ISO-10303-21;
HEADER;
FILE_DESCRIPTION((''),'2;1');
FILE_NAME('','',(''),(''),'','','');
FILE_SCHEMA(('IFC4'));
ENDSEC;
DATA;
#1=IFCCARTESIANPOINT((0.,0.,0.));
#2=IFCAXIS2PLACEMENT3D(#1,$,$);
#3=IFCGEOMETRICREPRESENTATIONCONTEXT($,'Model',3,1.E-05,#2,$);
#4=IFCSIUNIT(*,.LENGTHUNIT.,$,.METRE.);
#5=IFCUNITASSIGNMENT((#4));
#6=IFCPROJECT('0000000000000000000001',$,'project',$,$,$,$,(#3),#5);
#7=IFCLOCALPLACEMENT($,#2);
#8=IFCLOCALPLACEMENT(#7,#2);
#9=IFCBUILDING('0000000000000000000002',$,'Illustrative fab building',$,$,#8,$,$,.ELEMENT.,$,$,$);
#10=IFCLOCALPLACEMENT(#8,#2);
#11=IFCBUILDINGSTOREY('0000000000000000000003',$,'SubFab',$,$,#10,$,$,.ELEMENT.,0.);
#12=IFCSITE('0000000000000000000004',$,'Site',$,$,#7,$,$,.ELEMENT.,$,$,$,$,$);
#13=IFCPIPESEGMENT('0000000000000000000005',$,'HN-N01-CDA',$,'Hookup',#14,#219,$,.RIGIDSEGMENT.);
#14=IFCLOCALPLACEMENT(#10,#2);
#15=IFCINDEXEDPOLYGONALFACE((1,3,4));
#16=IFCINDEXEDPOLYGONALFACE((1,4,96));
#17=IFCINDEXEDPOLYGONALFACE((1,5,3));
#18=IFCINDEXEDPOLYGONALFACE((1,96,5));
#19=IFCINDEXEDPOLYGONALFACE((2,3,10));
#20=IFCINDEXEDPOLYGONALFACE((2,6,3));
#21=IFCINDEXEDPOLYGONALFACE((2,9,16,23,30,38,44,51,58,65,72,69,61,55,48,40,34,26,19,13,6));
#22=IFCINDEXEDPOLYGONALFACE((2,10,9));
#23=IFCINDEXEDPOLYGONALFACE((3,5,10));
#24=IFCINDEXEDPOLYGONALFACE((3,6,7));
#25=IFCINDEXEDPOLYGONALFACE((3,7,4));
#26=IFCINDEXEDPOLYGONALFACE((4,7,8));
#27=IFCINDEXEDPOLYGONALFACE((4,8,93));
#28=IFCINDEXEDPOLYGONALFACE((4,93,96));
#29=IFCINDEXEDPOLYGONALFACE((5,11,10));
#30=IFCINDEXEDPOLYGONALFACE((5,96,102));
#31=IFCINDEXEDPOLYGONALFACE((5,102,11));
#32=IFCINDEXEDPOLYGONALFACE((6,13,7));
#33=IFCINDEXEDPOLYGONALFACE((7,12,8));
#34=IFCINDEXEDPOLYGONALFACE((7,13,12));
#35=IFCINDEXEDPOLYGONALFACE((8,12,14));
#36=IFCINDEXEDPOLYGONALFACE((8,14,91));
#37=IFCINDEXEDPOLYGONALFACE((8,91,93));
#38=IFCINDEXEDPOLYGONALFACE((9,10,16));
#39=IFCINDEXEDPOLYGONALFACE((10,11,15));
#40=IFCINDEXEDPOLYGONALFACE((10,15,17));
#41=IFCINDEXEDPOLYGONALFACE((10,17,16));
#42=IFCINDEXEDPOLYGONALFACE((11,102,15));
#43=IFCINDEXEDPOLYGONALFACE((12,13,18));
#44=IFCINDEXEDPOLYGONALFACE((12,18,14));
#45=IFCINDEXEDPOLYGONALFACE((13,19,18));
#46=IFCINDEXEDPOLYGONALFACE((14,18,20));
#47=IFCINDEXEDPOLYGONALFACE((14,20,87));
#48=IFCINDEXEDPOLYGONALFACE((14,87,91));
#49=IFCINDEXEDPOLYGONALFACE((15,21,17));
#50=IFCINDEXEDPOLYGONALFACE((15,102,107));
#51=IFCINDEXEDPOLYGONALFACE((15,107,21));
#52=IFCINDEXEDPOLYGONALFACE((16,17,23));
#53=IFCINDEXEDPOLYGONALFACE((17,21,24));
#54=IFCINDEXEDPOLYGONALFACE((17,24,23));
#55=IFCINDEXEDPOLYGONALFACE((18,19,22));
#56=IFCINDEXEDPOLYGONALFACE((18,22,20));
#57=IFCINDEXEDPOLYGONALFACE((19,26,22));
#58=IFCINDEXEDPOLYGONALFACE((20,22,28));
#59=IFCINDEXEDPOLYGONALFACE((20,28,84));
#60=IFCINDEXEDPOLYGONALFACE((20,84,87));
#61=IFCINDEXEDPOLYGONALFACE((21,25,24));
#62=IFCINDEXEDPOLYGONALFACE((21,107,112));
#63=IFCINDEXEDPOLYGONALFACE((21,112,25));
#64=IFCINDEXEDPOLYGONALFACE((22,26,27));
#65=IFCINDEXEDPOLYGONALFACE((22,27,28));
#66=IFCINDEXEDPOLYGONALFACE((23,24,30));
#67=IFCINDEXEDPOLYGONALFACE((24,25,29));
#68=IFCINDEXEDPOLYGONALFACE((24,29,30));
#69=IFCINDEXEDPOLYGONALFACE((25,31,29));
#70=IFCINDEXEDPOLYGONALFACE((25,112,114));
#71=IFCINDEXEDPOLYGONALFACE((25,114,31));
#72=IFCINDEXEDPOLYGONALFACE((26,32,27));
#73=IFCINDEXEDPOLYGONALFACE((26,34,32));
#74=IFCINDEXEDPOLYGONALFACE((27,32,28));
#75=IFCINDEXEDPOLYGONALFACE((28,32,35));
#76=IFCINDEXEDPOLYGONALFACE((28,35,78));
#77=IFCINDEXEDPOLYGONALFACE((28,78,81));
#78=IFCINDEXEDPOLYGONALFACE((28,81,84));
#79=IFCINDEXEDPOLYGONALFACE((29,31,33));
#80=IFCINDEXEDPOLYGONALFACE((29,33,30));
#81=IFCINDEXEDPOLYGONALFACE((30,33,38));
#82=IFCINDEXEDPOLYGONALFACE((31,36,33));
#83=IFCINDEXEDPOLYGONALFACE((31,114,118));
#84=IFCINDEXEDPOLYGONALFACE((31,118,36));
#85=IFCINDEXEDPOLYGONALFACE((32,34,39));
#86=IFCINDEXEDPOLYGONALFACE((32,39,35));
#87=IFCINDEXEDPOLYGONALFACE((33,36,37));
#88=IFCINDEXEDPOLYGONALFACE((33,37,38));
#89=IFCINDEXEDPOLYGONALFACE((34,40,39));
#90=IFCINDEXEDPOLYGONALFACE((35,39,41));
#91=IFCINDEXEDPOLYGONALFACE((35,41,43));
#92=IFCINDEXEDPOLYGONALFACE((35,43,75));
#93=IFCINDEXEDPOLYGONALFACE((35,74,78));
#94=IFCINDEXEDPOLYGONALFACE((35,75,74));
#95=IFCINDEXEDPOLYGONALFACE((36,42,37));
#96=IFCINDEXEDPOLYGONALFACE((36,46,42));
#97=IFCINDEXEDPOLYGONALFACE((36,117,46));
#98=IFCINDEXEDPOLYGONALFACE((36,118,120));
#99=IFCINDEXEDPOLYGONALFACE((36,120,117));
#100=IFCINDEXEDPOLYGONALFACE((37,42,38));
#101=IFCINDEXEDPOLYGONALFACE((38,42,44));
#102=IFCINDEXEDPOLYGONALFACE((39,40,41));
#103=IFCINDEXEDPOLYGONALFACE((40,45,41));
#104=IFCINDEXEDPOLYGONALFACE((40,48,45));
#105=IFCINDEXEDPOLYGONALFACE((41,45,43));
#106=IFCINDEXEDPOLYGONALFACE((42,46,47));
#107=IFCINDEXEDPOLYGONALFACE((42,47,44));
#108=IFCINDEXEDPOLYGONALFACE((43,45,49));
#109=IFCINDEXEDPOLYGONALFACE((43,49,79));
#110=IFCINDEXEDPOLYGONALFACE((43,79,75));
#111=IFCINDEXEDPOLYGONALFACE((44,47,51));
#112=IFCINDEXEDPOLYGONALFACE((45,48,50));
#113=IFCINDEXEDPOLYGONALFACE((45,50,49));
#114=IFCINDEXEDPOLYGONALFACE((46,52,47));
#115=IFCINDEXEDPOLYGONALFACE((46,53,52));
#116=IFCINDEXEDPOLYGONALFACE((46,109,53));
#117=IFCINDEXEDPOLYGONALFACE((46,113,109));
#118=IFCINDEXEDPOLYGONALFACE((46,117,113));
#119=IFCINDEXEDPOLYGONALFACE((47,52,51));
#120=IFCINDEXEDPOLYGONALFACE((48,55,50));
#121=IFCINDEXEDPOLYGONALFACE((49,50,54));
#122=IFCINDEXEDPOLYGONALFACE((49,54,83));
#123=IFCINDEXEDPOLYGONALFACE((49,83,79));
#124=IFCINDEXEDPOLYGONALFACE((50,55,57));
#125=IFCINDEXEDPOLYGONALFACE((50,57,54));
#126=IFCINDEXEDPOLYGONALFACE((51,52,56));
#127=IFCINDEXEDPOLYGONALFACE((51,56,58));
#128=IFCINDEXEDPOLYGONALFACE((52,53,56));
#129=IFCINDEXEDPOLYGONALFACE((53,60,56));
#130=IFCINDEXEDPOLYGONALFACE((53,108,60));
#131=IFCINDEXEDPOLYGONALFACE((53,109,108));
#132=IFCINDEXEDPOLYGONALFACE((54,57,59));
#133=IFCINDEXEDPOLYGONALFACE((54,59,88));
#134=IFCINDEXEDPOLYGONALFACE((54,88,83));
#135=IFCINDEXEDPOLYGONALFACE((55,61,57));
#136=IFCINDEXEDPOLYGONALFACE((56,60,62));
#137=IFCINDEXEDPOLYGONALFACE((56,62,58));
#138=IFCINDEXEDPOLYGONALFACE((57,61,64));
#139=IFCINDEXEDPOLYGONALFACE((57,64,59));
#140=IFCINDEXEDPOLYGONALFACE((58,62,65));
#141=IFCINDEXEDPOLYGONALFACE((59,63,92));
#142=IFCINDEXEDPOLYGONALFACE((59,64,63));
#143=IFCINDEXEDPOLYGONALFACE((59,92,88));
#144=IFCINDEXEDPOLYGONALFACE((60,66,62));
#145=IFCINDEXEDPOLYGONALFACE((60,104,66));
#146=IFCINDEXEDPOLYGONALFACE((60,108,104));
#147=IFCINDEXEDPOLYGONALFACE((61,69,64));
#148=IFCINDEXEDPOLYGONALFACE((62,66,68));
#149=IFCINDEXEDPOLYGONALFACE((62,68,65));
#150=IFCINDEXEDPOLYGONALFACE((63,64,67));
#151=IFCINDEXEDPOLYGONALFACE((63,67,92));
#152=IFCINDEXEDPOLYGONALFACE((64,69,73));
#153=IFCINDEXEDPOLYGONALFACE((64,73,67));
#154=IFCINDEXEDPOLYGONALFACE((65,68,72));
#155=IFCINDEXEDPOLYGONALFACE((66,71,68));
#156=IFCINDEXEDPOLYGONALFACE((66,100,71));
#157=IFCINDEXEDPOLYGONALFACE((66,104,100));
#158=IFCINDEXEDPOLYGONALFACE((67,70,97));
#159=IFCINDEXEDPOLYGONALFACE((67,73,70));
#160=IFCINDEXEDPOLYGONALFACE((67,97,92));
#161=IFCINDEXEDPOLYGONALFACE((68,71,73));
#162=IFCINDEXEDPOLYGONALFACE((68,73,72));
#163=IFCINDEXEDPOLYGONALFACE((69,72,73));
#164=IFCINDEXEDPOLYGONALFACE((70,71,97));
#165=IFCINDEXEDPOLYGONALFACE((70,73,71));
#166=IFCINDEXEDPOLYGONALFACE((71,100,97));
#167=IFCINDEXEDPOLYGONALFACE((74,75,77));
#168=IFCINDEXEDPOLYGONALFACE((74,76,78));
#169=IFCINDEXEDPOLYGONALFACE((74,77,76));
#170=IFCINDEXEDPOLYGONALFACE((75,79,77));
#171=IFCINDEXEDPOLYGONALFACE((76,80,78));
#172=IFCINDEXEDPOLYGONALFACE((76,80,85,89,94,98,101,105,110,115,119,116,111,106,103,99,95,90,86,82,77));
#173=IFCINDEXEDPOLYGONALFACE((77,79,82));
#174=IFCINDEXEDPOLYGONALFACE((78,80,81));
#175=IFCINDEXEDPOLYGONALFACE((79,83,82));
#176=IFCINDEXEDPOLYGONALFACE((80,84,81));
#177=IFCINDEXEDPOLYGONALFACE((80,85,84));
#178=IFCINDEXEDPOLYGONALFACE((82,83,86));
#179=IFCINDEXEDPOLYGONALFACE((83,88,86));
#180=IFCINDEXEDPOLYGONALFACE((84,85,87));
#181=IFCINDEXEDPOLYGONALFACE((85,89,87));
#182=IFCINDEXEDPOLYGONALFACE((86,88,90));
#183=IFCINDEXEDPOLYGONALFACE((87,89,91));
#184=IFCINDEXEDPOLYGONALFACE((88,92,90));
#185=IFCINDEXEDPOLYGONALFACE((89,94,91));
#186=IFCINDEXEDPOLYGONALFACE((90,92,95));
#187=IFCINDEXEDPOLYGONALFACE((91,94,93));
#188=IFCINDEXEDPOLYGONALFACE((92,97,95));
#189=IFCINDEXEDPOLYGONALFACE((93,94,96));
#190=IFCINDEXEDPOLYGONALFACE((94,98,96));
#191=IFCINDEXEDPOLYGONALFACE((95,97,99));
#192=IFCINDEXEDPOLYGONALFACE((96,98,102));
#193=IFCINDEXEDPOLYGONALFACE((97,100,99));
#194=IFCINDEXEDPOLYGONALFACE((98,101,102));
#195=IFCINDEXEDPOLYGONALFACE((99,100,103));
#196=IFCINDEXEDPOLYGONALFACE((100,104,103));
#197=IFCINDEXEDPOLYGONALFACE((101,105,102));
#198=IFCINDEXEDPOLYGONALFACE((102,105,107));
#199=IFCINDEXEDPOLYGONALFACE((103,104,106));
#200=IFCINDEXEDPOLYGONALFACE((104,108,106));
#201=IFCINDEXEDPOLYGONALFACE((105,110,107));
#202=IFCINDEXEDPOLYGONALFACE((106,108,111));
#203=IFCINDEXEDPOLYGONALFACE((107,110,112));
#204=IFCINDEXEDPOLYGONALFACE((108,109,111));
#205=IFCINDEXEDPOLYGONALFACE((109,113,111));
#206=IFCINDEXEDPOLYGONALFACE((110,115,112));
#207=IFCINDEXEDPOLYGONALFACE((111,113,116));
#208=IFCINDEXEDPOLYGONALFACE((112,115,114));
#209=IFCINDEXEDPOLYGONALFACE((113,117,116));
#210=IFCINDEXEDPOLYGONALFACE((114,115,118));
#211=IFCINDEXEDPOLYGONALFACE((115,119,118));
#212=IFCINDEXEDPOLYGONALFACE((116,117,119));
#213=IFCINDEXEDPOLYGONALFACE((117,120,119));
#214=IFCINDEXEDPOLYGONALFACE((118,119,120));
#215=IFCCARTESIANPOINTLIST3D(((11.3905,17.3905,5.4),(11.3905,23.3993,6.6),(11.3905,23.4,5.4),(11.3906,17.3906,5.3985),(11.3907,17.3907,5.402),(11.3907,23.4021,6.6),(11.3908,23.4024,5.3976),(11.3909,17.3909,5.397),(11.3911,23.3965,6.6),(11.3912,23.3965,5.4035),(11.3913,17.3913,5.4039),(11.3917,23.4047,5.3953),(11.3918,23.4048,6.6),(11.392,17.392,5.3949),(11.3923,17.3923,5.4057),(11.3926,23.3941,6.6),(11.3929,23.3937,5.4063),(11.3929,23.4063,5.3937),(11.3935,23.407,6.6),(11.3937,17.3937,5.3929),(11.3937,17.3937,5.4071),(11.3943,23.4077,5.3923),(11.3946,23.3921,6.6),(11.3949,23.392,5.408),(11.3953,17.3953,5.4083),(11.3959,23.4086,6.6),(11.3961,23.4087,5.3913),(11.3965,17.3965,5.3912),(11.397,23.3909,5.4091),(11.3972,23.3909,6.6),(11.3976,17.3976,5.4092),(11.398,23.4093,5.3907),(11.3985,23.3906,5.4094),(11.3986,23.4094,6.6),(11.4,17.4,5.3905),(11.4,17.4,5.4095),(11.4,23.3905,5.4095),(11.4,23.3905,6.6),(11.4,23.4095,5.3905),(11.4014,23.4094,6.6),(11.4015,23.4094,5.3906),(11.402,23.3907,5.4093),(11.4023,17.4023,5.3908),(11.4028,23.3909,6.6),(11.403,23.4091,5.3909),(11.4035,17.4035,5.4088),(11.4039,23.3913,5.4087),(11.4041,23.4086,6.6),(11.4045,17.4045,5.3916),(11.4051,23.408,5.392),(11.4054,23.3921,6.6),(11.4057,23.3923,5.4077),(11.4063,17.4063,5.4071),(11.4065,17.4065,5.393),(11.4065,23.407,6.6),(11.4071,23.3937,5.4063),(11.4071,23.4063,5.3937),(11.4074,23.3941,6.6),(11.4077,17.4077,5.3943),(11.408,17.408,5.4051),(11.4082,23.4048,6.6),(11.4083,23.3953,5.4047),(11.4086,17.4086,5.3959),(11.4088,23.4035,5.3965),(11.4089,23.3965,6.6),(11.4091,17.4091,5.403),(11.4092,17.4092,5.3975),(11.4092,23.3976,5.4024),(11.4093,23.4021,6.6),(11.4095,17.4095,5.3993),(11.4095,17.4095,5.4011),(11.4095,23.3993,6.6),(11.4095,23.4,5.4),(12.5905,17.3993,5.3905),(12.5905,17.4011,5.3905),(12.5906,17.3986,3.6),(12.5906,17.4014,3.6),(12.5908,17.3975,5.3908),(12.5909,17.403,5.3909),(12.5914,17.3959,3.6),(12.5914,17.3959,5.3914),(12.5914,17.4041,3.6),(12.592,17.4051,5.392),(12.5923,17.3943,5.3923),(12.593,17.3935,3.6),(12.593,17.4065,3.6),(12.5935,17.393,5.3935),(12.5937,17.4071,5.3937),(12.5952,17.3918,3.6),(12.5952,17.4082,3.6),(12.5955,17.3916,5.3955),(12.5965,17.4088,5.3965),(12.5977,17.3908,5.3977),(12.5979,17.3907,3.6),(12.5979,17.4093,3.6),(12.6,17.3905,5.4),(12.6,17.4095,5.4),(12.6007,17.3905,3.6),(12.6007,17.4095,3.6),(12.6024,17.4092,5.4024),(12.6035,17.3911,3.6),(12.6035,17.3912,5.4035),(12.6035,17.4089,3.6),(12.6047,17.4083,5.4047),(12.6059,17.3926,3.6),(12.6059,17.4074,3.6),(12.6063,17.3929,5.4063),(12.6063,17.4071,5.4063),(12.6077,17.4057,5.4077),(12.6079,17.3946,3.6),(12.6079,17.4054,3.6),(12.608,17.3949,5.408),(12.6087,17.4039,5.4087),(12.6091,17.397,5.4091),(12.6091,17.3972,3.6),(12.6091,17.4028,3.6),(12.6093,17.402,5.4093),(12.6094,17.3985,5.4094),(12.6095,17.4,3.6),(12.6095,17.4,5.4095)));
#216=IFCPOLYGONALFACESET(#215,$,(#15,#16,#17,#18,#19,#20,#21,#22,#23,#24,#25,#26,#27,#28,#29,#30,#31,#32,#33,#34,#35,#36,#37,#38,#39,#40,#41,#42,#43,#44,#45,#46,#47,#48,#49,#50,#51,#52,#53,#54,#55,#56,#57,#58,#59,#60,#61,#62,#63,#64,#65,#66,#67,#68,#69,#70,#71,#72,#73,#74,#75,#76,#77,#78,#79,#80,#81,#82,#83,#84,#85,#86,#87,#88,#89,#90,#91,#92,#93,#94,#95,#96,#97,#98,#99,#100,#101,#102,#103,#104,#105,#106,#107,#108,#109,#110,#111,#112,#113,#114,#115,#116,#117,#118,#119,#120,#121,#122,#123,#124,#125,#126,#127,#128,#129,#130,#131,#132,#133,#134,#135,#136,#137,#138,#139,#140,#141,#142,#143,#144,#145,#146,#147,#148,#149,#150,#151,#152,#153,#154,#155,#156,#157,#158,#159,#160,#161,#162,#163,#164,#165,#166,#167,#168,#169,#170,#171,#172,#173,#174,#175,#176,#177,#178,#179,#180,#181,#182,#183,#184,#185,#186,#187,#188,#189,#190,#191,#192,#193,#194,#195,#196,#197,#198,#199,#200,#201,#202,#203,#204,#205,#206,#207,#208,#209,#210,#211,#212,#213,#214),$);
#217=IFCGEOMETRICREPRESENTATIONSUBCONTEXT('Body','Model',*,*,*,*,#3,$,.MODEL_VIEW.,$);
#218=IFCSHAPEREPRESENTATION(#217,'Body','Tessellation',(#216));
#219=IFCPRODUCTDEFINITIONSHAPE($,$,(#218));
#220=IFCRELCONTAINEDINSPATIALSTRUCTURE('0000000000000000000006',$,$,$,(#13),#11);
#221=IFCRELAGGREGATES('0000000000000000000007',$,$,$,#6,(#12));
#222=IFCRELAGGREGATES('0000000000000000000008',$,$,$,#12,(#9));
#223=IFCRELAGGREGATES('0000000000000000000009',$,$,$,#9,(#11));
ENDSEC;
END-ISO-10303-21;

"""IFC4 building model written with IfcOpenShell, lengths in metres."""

from ifc_helpers import new_model, entity, si_unit, origin, place, context, subcontext, project, spatial, element, save


model = new_model("IFC4")

# Units and contexts
model_context = context("Model", 3, precision=1e-05, world=origin())
body_context = subcontext(model_context, "Body", "Model", "MODEL_VIEW")
ifc_project = project(units=[si_unit("LENGTHUNIT", "METRE")], contexts=[model_context])

# Site, building, storey
site_placement = place(None, origin())
site = spatial("IfcSite", under=ifc_project, at=site_placement, Name="Site", CompositionType="ELEMENT")
building_placement = place(site_placement, origin())
building = spatial("IfcBuilding", under=site, at=building_placement, Name="Illustrative fab building", CompositionType="ELEMENT")
storey_placement = place(building_placement, origin())
storey = spatial("IfcBuildingStorey", under=building, at=storey_placement, Name="SubFab", CompositionType="ELEMENT", Elevation=0.0)

# Pipe segment
pipe_segment_1_placement = place(storey_placement, origin())
element("IfcPipeSegment", 1, at=pipe_segment_1_placement, inside=storey, Name="HN-N01-CDA", ObjectType="Hookup", PredefinedType="RIGIDSEGMENT", context=body_context, shape_type="AdvancedSweptSolid", body=[
    entity("IfcSweptDiskSolid", entity("IfcPolyline", [entity("IfcCartesianPoint", [12.6, 17.4, 3.6]), entity("IfcCartesianPoint", [12.6, 17.4, 5.4]), entity("IfcCartesianPoint", [11.4, 17.4, 5.4]), entity("IfcCartesianPoint", [11.4, 23.4, 5.4]), entity("IfcCartesianPoint", [11.4, 23.4, 6.6])]), 0.0095),
])

save(model, "model.ifc")
